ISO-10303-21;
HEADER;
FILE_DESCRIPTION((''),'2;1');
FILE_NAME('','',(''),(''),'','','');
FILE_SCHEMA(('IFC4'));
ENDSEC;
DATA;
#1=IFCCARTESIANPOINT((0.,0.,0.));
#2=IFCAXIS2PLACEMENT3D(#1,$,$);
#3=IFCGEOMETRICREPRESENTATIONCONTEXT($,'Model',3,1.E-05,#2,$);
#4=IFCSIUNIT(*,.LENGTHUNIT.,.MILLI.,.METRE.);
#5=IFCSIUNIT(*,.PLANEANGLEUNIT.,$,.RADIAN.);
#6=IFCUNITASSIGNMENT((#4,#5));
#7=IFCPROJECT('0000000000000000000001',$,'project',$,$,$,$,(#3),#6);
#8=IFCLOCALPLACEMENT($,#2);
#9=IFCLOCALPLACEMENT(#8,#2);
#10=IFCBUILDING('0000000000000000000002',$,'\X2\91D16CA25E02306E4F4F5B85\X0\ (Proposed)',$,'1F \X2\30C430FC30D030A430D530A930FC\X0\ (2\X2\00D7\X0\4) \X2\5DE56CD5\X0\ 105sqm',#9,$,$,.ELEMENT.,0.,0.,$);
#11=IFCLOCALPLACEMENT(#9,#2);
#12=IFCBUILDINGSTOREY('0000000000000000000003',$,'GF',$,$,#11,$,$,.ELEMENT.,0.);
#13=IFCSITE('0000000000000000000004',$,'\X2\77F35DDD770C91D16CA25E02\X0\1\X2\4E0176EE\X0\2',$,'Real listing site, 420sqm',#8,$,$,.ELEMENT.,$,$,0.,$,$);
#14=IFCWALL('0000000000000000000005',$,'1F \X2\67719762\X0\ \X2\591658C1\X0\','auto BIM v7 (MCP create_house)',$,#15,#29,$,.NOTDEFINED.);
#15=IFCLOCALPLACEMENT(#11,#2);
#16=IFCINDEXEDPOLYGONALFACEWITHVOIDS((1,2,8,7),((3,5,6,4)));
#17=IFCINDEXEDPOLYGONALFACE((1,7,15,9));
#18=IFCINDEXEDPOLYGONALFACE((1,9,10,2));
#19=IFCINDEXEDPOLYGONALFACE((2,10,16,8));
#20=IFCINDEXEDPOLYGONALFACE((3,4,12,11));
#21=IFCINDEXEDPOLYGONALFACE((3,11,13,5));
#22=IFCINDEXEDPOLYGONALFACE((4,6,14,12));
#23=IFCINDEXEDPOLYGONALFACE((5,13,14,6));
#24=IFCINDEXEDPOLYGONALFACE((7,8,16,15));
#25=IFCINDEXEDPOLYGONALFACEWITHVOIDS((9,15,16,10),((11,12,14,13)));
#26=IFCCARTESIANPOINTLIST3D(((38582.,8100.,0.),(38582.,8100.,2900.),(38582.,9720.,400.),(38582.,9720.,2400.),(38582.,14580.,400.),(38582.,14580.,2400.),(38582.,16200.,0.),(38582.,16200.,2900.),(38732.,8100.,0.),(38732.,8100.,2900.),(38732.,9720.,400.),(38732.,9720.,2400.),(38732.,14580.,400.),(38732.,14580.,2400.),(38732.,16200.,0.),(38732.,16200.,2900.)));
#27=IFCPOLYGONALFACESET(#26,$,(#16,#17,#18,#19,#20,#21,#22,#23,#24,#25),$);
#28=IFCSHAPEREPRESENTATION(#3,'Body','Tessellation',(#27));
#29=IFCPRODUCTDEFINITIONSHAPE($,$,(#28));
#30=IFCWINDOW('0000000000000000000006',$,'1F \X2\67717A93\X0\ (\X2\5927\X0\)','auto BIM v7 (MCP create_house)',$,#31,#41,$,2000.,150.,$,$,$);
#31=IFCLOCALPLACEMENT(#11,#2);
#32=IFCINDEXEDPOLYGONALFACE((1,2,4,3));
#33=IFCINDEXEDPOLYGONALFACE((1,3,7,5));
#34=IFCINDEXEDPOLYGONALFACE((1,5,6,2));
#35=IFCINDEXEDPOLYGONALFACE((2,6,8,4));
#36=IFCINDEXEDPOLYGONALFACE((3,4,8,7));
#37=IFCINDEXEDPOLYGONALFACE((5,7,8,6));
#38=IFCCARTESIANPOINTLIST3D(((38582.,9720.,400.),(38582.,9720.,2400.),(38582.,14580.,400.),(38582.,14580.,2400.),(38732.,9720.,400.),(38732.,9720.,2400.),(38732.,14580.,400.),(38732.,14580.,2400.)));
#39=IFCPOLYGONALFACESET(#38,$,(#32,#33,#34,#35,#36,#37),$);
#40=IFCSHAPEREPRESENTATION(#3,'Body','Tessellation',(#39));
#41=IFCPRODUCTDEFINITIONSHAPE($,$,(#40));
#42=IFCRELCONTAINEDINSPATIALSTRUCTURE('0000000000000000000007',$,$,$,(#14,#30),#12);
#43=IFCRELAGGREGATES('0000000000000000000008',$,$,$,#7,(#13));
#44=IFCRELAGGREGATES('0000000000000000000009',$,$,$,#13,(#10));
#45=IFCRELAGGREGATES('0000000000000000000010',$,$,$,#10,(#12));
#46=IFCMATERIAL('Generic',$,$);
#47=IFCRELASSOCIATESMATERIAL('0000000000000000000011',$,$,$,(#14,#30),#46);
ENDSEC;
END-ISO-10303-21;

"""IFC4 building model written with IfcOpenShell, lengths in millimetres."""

from ifc_helpers import new_model, si_unit, frame, frame_2d, origin, place, context, project, spatial, rectangle, extrude, material, element, fill, save


model = new_model("IFC4")

# Units and contexts
model_context = context("Model", 3, precision=1e-05, world=origin())
ifc_project = project(units=[si_unit("LENGTHUNIT", "METRE", prefix="MILLI"), si_unit("PLANEANGLEUNIT", "RADIAN")], contexts=[model_context])

# Site, building, storey
site_placement = place(None, origin())
site = spatial("IfcSite", under=ifc_project, at=site_placement, Name="石川県金沢市1丁目2", ObjectType="Real listing site, 420sqm", CompositionType="ELEMENT", RefElevation=0.0)
building_placement = place(site_placement, origin())
building = spatial("IfcBuilding", under=site, at=building_placement, Name="金沢市の住宅 (Proposed)", ObjectType="1F ツーバイフォー (2×4) 工法 105sqm", CompositionType="ELEMENT", ElevationOfRefHeight=0.0, ElevationOfTerrain=0.0)
storey_placement = place(building_placement, origin())
storey = spatial("IfcBuildingStorey", under=building, at=storey_placement, Name="GF", CompositionType="ELEMENT", Elevation=0.0)

# Shared definitions
ifc_material = material(Name="Generic")

# Wall, opening, window
wall_1_placement = place(storey_placement, frame((19291.0, 4050.0, 0.0)))
wall_1 = element("IfcWall", 1, at=wall_1_placement, inside=storey, material=ifc_material, Name="1F 東面 外壁", Description="auto BIM v7 (MCP create_house)", PredefinedType="NOTDEFINED", context=model_context, shape_type="SweptSolid", body=[
    extrude(rectangle(XDim=150.0, YDim=8100.0, at=frame_2d((75.0, 4050.0))), frame((19291.0, 4050.0, 0.0)), (0.0, 0.0, 1.0), 2900.0),
])
opening_1_placement = place(storey_placement, frame((19291.0, 4860.0, 200.0)))
opening_1 = element("IfcOpeningElement", 2, at=opening_1_placement, cuts=wall_1, PredefinedType="NOTDEFINED", context=model_context, shape_type="SweptSolid", body=[
    extrude(rectangle(XDim=150.0, YDim=4860.0, at=frame_2d((75.0, 2430.0))), frame((19291.0, 4860.0, 200.0)), (0.0, 0.0, 1.0), 2000.0),
])
window_1_placement = place(storey_placement, frame((19291.0, 4860.0, 200.0)))
window_1 = element("IfcWindow", 3, at=window_1_placement, inside=storey, material=ifc_material, Name="1F 東窓 (大)", Description="auto BIM v7 (MCP create_house)", OverallHeight=2000.0, OverallWidth=150.0, context=model_context, shape_type="SweptSolid", body=[
    extrude(rectangle(XDim=150.0, YDim=4860.0, at=frame_2d((75.0, 2430.0))), frame((19291.0, 4860.0, 200.0)), (0.0, 0.0, 1.0), 2000.0),
])
fill(opening_1, window_1)

save(model, "model.ifc")
